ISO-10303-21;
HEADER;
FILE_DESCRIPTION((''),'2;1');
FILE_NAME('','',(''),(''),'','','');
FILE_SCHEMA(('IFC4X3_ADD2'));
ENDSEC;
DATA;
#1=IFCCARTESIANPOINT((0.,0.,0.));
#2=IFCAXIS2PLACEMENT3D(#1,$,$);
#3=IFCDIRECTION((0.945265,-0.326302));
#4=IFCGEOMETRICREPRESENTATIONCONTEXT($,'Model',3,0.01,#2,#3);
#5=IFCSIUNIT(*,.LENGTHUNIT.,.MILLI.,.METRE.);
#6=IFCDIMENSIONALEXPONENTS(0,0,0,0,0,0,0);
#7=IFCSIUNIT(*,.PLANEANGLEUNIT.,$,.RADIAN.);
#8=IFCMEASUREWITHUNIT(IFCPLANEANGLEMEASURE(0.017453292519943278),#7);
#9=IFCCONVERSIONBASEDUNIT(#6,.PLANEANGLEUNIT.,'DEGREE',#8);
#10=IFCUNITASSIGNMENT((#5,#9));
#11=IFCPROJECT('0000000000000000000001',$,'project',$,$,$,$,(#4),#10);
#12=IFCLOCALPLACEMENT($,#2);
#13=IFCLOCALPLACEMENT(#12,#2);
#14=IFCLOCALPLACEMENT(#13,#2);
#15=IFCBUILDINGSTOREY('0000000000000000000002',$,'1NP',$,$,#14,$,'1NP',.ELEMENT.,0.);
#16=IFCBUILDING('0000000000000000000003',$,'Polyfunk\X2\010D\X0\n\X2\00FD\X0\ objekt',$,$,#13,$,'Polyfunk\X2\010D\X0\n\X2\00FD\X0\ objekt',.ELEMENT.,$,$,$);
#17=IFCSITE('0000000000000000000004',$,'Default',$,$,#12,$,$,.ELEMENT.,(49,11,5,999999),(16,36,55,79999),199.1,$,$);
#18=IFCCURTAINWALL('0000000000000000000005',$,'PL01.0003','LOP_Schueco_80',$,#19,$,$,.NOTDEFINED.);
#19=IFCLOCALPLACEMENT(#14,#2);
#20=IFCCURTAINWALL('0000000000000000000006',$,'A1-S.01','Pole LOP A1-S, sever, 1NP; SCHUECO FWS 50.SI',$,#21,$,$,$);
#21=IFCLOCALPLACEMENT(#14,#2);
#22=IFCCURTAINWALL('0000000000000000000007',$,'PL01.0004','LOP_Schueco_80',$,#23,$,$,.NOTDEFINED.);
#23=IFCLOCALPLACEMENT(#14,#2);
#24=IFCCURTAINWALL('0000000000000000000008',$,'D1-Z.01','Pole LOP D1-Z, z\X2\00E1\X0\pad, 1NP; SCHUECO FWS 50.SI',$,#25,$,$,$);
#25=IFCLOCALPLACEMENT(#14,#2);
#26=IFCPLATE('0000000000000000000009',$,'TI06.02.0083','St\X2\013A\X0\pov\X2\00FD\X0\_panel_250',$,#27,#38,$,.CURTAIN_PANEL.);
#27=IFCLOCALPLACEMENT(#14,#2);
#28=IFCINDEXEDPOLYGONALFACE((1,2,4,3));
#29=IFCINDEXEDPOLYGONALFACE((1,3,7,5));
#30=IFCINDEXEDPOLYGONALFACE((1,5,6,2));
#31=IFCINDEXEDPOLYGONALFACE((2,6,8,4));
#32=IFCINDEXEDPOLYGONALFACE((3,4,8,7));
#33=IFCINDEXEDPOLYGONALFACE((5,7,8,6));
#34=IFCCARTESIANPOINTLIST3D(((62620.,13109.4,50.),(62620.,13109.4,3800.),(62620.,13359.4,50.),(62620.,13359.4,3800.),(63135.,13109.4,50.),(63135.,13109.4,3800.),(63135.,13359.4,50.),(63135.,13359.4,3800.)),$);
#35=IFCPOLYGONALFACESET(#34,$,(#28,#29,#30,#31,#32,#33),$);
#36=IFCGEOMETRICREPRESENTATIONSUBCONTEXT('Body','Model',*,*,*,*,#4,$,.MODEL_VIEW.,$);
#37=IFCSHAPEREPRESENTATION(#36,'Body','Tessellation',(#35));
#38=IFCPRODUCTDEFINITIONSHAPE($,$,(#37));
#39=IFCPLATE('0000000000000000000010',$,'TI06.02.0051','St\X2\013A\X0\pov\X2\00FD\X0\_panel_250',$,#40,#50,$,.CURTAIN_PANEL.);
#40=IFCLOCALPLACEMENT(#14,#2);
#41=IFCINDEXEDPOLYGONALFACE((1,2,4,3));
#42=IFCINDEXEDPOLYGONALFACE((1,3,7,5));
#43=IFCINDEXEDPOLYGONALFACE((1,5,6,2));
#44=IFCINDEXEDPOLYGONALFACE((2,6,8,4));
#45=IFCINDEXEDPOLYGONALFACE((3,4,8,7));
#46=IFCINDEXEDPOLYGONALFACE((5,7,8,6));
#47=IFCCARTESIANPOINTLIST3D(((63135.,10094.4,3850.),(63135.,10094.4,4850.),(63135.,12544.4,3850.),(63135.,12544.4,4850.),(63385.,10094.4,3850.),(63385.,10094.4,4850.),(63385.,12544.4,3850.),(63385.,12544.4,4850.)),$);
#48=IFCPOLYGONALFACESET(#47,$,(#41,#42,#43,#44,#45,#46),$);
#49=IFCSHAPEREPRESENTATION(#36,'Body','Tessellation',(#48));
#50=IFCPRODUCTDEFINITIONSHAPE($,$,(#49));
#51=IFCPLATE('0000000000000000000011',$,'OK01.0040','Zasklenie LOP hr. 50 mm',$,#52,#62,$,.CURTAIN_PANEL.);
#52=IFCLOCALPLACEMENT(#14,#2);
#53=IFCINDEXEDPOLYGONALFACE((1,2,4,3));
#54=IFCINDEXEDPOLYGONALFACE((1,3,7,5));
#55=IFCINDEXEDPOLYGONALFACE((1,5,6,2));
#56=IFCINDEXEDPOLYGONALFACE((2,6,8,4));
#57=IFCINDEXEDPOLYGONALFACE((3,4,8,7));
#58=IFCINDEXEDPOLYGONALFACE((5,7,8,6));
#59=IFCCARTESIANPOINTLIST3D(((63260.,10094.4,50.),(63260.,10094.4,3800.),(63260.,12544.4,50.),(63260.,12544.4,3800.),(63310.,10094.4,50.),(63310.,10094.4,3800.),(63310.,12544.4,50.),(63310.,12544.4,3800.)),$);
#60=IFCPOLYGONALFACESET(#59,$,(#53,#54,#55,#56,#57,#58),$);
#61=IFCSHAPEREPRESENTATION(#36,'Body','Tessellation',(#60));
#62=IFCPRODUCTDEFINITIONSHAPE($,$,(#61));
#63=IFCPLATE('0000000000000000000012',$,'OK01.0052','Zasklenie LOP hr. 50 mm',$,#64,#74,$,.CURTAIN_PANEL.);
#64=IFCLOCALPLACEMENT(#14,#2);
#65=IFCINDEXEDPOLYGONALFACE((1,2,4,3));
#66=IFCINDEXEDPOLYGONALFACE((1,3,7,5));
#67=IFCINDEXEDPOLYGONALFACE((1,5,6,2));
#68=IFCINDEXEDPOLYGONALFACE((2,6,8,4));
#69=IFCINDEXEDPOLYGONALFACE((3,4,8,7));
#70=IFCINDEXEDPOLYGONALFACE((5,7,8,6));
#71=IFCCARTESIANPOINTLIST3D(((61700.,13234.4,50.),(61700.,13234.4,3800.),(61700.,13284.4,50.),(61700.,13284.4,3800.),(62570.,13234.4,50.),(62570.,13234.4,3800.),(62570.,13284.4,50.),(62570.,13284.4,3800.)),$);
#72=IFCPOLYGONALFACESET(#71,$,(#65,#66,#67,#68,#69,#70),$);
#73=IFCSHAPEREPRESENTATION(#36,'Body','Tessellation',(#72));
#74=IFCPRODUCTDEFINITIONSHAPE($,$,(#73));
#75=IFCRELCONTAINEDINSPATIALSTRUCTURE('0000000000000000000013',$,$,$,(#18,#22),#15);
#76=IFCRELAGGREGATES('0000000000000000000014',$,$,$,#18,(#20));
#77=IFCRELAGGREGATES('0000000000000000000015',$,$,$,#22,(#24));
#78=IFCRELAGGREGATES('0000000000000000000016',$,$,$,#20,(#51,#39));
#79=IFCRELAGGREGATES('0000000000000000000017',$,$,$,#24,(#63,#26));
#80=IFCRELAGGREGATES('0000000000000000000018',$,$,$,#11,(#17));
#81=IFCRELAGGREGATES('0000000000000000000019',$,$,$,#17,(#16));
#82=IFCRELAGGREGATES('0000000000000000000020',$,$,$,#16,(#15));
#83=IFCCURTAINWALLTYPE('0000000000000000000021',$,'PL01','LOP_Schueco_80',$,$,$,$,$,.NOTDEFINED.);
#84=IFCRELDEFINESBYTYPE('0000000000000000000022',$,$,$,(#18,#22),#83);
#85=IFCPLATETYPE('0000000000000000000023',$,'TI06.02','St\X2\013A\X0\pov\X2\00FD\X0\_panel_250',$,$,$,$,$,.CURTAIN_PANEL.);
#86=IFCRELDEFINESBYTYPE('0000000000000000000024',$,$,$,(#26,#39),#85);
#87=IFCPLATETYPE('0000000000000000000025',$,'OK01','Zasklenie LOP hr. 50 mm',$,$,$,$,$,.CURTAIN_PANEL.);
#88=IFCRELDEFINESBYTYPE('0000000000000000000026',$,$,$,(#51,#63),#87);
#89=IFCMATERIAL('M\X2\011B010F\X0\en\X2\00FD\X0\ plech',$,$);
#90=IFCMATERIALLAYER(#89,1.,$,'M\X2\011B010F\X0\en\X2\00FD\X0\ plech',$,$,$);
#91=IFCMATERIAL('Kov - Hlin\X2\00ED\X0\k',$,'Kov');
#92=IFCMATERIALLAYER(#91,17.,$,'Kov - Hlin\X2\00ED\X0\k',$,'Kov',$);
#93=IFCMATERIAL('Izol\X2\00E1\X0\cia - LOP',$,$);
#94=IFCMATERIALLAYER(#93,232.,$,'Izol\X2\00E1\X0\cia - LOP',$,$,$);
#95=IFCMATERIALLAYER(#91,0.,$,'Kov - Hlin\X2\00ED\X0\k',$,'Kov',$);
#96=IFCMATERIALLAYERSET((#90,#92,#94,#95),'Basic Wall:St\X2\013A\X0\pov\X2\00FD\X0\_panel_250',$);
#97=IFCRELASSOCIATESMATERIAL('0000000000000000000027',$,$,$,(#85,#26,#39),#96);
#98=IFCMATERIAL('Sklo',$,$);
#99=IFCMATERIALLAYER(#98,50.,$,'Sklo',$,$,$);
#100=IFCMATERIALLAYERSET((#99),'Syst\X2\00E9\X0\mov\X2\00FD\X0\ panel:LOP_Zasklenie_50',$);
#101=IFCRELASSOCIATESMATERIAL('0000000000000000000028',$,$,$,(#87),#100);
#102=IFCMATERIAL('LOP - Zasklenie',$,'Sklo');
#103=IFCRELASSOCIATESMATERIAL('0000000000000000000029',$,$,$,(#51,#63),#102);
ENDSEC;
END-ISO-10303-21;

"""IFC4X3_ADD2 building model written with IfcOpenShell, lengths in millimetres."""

from ifc_helpers import new_model, entity, si_unit, converted_unit, direction, frame, frame_2d, origin, place, context, subcontext, project, spatial, rectangle, extrude, source, transform, mapped, material, layer, layer_set, layer_usage, type_object, type_shapes, element, aggregate, save


model = new_model("IFC4X3_ADD2")

# Units and contexts
model_context = context("Model", 3, precision=0.01, world=origin(), true_north=direction((0.945265, -0.326302)))
body_context = subcontext(model_context, "Body", "Model", "MODEL_VIEW")
ifc_project = project(units=[si_unit("LENGTHUNIT", "METRE", prefix="MILLI"), converted_unit("PLANEANGLEUNIT", "DEGREE", entity("IfcPlaneAngleMeasure", 0.017453292519943278), si_unit("PLANEANGLEUNIT", "RADIAN"), dimensions=[0, 0, 0, 0, 0, 0, 0])], contexts=[model_context])

# Site, building, storey
site_placement = place(None, origin())
site = spatial("IfcSite", under=ifc_project, at=site_placement, Name="Default", CompositionType="ELEMENT", RefLatitude=(49, 11, 5, 999999), RefLongitude=(16, 36, 55, 79999), RefElevation=199.1)
building_placement = place(site_placement, origin())
building = spatial("IfcBuilding", under=site, at=building_placement, Name="Polyfunkčný objekt", LongName="Polyfunkčný objekt", CompositionType="ELEMENT")
storey_placement = place(building_placement, origin())
storey = spatial("IfcBuildingStorey", under=building, at=storey_placement, Name="1NP", LongName="1NP", CompositionType="ELEMENT", Elevation=0.0)

# Curtain walls
curtain_wall_type = type_object("IfcCurtainWallType", Name="PL01", Description="LOP_Schueco_80", PredefinedType="NOTDEFINED")
curtain_wall_1_placement = place(storey_placement, origin())
curtain_wall_1 = element("IfcCurtainWall", 1, at=curtain_wall_1_placement, inside=storey, type_object=curtain_wall_type, Name="PL01.0003", Description="LOP_Schueco_80", PredefinedType="NOTDEFINED")
curtain_wall_2 = element("IfcCurtainWall", 2, Name="A1-S.01", Description="Pole LOP A1-S, sever, 1NP; SCHUECO FWS 50.SI")
aggregate(curtain_wall_1, [curtain_wall_2])
curtain_wall_3_placement = place(storey_placement, origin())
curtain_wall_3 = element("IfcCurtainWall", 3, at=curtain_wall_3_placement, inside=storey, type_object=curtain_wall_type, Name="PL01.0004", Description="LOP_Schueco_80", PredefinedType="NOTDEFINED")
curtain_wall_4 = element("IfcCurtainWall", 4, Name="D1-Z.01", Description="Pole LOP D1-Z, západ, 1NP; SCHUECO FWS 50.SI")
aggregate(curtain_wall_3, [curtain_wall_4])

# Plates
ifc_material_1 = material(Name="Měďený plech")
ifc_layer_1 = layer(ifc_material_1, 1.0, Name="Měďený plech")
ifc_material_2 = material(Name="Kov - Hliník", Category="Kov")
ifc_layer_2 = layer(ifc_material_2, 17.0, Name="Kov - Hliník", Category="Kov")
ifc_material_3 = material(Name="Izolácia - LOP")
ifc_layer_3 = layer(ifc_material_3, 232.0, Name="Izolácia - LOP")
ifc_layer_4 = layer(ifc_material_2, 0.0, Name="Kov - Hliník", Category="Kov")
ifc_layer_set_1 = layer_set([ifc_layer_1, ifc_layer_2, ifc_layer_3, ifc_layer_4], Name="Basic Wall:Stĺpový_panel_250")
ifc_layer_usage_1 = layer_usage(ifc_layer_set_1, "AXIS2", "NEGATIVE", 125.0)
plate_type_1 = type_object("IfcPlateType", Name="TI06.02", Description="Stĺpový_panel_250", PredefinedType="CURTAIN_PANEL", material=ifc_layer_set_1)
plate_1_placement = place(storey_placement, frame((62620.0, 13234.4, 50.0)))
plate_1 = element("IfcPlate", 5, at=plate_1_placement, type_object=plate_type_1, material=ifc_layer_usage_1, Name="TI06.02.0083", Description="Stĺpový_panel_250", PredefinedType="CURTAIN_PANEL", context=body_context, shape_type="SweptSolid", body=[
    extrude(rectangle(XDim=250.0, YDim=515.0, at=frame_2d((0.0, 0.0), x_axis=(1.0, 0.0))), frame((257.5, 0.0, 0.0), z_axis=(0.0, 0.0, 1.0), x_axis=(0.0, 1.0, 0.0)), (0.0, 0.0, 1.0), 3750.0),
])
ifc_layer_usage_2 = layer_usage(ifc_layer_set_1, "AXIS2", "NEGATIVE", 125.0)
plate_2_placement = place(storey_placement, frame((63260.0, 12544.4, 3850.0), z_axis=(0.0, 0.0, 1.0), x_axis=(0.0, -1.0, 0.0)))
plate_2 = element("IfcPlate", 6, at=plate_2_placement, type_object=plate_type_1, material=ifc_layer_usage_2, Name="TI06.02.0051", Description="Stĺpový_panel_250", PredefinedType="CURTAIN_PANEL", context=body_context, shape_type="SweptSolid", body=[
    extrude(rectangle(XDim=250.0, YDim=2450.0, at=frame_2d((0.0, 0.0), x_axis=(1.0, 0.0))), frame((1225.0, 0.0, 0.0), z_axis=(0.0, 0.0, 1.0), x_axis=(0.0, 1.0, 0.0)), (0.0, 0.0, 1.0), 1000.0),
])
ifc_material_4 = material(Name="LOP - Zasklenie", Category="Sklo")
ifc_material_5 = material(Name="Sklo")
ifc_layer_5 = layer(ifc_material_5, 50.0, Name="Sklo")
ifc_layer_set_2 = layer_set([ifc_layer_5], Name="Systémový panel:LOP_Zasklenie_50")
plate_type_2 = type_object("IfcPlateType", Name="OK01", Description="Zasklenie LOP hr. 50 mm", PredefinedType="CURTAIN_PANEL", material=ifc_layer_set_2)
shared_shape_1 = source(origin(), body_context, "Body", "SweptSolid", [
    extrude(rectangle(XDim=3750.0, YDim=2450.0, at=frame_2d((-141.7, 0.0), x_axis=(1.0, 0.0))), frame((0.0, 0.0, 2016.7), z_axis=(0.0, 1.0, 0.0), x_axis=(0.0, 0.0, 1.0)), (0.0, 0.0, 1.0), 50.0),
])
plate_3_placement = place(curtain_wall_1_placement, frame((63260.0, 11319.4, 50.0), z_axis=(0.0, 0.0, 1.0), x_axis=(0.0, -1.0, 0.0)))
plate_3 = element("IfcPlate", 7, at=plate_3_placement, type_object=plate_type_2, material=ifc_material_4, Name="OK01.0040", Description="Zasklenie LOP hr. 50 mm", PredefinedType="CURTAIN_PANEL", context=body_context, shape_type="MappedRepresentation", body=[
    mapped(shared_shape_1, transform((0.0, 0.0, 0.0), scale=1.0)),
])
aggregate(curtain_wall_2, [plate_3, plate_2])
shared_shape_2 = source(origin(), body_context, "Body", "SweptSolid", [
    extrude(rectangle(XDim=3750.0, YDim=870.0, at=frame_2d((-141.7, 0.0), x_axis=(1.0, 0.0))), frame((0.0, 0.0, 2016.7), z_axis=(0.0, 1.0, 0.0), x_axis=(0.0, 0.0, 1.0)), (0.0, 0.0, 1.0), 50.0),
])
type_shapes(plate_type_2, [shared_shape_1, shared_shape_2])
plate_4_placement = place(curtain_wall_3_placement, frame((62135.0, 13234.4, 50.0)))
plate_4 = element("IfcPlate", 8, at=plate_4_placement, type_object=plate_type_2, material=ifc_material_4, Name="OK01.0052", Description="Zasklenie LOP hr. 50 mm", PredefinedType="CURTAIN_PANEL", context=body_context, shape_type="MappedRepresentation", body=[
    mapped(shared_shape_2, transform((0.0, 0.0, 0.0), scale=1.0)),
])
aggregate(curtain_wall_4, [plate_4, plate_1])

save(model, "model.ifc")
